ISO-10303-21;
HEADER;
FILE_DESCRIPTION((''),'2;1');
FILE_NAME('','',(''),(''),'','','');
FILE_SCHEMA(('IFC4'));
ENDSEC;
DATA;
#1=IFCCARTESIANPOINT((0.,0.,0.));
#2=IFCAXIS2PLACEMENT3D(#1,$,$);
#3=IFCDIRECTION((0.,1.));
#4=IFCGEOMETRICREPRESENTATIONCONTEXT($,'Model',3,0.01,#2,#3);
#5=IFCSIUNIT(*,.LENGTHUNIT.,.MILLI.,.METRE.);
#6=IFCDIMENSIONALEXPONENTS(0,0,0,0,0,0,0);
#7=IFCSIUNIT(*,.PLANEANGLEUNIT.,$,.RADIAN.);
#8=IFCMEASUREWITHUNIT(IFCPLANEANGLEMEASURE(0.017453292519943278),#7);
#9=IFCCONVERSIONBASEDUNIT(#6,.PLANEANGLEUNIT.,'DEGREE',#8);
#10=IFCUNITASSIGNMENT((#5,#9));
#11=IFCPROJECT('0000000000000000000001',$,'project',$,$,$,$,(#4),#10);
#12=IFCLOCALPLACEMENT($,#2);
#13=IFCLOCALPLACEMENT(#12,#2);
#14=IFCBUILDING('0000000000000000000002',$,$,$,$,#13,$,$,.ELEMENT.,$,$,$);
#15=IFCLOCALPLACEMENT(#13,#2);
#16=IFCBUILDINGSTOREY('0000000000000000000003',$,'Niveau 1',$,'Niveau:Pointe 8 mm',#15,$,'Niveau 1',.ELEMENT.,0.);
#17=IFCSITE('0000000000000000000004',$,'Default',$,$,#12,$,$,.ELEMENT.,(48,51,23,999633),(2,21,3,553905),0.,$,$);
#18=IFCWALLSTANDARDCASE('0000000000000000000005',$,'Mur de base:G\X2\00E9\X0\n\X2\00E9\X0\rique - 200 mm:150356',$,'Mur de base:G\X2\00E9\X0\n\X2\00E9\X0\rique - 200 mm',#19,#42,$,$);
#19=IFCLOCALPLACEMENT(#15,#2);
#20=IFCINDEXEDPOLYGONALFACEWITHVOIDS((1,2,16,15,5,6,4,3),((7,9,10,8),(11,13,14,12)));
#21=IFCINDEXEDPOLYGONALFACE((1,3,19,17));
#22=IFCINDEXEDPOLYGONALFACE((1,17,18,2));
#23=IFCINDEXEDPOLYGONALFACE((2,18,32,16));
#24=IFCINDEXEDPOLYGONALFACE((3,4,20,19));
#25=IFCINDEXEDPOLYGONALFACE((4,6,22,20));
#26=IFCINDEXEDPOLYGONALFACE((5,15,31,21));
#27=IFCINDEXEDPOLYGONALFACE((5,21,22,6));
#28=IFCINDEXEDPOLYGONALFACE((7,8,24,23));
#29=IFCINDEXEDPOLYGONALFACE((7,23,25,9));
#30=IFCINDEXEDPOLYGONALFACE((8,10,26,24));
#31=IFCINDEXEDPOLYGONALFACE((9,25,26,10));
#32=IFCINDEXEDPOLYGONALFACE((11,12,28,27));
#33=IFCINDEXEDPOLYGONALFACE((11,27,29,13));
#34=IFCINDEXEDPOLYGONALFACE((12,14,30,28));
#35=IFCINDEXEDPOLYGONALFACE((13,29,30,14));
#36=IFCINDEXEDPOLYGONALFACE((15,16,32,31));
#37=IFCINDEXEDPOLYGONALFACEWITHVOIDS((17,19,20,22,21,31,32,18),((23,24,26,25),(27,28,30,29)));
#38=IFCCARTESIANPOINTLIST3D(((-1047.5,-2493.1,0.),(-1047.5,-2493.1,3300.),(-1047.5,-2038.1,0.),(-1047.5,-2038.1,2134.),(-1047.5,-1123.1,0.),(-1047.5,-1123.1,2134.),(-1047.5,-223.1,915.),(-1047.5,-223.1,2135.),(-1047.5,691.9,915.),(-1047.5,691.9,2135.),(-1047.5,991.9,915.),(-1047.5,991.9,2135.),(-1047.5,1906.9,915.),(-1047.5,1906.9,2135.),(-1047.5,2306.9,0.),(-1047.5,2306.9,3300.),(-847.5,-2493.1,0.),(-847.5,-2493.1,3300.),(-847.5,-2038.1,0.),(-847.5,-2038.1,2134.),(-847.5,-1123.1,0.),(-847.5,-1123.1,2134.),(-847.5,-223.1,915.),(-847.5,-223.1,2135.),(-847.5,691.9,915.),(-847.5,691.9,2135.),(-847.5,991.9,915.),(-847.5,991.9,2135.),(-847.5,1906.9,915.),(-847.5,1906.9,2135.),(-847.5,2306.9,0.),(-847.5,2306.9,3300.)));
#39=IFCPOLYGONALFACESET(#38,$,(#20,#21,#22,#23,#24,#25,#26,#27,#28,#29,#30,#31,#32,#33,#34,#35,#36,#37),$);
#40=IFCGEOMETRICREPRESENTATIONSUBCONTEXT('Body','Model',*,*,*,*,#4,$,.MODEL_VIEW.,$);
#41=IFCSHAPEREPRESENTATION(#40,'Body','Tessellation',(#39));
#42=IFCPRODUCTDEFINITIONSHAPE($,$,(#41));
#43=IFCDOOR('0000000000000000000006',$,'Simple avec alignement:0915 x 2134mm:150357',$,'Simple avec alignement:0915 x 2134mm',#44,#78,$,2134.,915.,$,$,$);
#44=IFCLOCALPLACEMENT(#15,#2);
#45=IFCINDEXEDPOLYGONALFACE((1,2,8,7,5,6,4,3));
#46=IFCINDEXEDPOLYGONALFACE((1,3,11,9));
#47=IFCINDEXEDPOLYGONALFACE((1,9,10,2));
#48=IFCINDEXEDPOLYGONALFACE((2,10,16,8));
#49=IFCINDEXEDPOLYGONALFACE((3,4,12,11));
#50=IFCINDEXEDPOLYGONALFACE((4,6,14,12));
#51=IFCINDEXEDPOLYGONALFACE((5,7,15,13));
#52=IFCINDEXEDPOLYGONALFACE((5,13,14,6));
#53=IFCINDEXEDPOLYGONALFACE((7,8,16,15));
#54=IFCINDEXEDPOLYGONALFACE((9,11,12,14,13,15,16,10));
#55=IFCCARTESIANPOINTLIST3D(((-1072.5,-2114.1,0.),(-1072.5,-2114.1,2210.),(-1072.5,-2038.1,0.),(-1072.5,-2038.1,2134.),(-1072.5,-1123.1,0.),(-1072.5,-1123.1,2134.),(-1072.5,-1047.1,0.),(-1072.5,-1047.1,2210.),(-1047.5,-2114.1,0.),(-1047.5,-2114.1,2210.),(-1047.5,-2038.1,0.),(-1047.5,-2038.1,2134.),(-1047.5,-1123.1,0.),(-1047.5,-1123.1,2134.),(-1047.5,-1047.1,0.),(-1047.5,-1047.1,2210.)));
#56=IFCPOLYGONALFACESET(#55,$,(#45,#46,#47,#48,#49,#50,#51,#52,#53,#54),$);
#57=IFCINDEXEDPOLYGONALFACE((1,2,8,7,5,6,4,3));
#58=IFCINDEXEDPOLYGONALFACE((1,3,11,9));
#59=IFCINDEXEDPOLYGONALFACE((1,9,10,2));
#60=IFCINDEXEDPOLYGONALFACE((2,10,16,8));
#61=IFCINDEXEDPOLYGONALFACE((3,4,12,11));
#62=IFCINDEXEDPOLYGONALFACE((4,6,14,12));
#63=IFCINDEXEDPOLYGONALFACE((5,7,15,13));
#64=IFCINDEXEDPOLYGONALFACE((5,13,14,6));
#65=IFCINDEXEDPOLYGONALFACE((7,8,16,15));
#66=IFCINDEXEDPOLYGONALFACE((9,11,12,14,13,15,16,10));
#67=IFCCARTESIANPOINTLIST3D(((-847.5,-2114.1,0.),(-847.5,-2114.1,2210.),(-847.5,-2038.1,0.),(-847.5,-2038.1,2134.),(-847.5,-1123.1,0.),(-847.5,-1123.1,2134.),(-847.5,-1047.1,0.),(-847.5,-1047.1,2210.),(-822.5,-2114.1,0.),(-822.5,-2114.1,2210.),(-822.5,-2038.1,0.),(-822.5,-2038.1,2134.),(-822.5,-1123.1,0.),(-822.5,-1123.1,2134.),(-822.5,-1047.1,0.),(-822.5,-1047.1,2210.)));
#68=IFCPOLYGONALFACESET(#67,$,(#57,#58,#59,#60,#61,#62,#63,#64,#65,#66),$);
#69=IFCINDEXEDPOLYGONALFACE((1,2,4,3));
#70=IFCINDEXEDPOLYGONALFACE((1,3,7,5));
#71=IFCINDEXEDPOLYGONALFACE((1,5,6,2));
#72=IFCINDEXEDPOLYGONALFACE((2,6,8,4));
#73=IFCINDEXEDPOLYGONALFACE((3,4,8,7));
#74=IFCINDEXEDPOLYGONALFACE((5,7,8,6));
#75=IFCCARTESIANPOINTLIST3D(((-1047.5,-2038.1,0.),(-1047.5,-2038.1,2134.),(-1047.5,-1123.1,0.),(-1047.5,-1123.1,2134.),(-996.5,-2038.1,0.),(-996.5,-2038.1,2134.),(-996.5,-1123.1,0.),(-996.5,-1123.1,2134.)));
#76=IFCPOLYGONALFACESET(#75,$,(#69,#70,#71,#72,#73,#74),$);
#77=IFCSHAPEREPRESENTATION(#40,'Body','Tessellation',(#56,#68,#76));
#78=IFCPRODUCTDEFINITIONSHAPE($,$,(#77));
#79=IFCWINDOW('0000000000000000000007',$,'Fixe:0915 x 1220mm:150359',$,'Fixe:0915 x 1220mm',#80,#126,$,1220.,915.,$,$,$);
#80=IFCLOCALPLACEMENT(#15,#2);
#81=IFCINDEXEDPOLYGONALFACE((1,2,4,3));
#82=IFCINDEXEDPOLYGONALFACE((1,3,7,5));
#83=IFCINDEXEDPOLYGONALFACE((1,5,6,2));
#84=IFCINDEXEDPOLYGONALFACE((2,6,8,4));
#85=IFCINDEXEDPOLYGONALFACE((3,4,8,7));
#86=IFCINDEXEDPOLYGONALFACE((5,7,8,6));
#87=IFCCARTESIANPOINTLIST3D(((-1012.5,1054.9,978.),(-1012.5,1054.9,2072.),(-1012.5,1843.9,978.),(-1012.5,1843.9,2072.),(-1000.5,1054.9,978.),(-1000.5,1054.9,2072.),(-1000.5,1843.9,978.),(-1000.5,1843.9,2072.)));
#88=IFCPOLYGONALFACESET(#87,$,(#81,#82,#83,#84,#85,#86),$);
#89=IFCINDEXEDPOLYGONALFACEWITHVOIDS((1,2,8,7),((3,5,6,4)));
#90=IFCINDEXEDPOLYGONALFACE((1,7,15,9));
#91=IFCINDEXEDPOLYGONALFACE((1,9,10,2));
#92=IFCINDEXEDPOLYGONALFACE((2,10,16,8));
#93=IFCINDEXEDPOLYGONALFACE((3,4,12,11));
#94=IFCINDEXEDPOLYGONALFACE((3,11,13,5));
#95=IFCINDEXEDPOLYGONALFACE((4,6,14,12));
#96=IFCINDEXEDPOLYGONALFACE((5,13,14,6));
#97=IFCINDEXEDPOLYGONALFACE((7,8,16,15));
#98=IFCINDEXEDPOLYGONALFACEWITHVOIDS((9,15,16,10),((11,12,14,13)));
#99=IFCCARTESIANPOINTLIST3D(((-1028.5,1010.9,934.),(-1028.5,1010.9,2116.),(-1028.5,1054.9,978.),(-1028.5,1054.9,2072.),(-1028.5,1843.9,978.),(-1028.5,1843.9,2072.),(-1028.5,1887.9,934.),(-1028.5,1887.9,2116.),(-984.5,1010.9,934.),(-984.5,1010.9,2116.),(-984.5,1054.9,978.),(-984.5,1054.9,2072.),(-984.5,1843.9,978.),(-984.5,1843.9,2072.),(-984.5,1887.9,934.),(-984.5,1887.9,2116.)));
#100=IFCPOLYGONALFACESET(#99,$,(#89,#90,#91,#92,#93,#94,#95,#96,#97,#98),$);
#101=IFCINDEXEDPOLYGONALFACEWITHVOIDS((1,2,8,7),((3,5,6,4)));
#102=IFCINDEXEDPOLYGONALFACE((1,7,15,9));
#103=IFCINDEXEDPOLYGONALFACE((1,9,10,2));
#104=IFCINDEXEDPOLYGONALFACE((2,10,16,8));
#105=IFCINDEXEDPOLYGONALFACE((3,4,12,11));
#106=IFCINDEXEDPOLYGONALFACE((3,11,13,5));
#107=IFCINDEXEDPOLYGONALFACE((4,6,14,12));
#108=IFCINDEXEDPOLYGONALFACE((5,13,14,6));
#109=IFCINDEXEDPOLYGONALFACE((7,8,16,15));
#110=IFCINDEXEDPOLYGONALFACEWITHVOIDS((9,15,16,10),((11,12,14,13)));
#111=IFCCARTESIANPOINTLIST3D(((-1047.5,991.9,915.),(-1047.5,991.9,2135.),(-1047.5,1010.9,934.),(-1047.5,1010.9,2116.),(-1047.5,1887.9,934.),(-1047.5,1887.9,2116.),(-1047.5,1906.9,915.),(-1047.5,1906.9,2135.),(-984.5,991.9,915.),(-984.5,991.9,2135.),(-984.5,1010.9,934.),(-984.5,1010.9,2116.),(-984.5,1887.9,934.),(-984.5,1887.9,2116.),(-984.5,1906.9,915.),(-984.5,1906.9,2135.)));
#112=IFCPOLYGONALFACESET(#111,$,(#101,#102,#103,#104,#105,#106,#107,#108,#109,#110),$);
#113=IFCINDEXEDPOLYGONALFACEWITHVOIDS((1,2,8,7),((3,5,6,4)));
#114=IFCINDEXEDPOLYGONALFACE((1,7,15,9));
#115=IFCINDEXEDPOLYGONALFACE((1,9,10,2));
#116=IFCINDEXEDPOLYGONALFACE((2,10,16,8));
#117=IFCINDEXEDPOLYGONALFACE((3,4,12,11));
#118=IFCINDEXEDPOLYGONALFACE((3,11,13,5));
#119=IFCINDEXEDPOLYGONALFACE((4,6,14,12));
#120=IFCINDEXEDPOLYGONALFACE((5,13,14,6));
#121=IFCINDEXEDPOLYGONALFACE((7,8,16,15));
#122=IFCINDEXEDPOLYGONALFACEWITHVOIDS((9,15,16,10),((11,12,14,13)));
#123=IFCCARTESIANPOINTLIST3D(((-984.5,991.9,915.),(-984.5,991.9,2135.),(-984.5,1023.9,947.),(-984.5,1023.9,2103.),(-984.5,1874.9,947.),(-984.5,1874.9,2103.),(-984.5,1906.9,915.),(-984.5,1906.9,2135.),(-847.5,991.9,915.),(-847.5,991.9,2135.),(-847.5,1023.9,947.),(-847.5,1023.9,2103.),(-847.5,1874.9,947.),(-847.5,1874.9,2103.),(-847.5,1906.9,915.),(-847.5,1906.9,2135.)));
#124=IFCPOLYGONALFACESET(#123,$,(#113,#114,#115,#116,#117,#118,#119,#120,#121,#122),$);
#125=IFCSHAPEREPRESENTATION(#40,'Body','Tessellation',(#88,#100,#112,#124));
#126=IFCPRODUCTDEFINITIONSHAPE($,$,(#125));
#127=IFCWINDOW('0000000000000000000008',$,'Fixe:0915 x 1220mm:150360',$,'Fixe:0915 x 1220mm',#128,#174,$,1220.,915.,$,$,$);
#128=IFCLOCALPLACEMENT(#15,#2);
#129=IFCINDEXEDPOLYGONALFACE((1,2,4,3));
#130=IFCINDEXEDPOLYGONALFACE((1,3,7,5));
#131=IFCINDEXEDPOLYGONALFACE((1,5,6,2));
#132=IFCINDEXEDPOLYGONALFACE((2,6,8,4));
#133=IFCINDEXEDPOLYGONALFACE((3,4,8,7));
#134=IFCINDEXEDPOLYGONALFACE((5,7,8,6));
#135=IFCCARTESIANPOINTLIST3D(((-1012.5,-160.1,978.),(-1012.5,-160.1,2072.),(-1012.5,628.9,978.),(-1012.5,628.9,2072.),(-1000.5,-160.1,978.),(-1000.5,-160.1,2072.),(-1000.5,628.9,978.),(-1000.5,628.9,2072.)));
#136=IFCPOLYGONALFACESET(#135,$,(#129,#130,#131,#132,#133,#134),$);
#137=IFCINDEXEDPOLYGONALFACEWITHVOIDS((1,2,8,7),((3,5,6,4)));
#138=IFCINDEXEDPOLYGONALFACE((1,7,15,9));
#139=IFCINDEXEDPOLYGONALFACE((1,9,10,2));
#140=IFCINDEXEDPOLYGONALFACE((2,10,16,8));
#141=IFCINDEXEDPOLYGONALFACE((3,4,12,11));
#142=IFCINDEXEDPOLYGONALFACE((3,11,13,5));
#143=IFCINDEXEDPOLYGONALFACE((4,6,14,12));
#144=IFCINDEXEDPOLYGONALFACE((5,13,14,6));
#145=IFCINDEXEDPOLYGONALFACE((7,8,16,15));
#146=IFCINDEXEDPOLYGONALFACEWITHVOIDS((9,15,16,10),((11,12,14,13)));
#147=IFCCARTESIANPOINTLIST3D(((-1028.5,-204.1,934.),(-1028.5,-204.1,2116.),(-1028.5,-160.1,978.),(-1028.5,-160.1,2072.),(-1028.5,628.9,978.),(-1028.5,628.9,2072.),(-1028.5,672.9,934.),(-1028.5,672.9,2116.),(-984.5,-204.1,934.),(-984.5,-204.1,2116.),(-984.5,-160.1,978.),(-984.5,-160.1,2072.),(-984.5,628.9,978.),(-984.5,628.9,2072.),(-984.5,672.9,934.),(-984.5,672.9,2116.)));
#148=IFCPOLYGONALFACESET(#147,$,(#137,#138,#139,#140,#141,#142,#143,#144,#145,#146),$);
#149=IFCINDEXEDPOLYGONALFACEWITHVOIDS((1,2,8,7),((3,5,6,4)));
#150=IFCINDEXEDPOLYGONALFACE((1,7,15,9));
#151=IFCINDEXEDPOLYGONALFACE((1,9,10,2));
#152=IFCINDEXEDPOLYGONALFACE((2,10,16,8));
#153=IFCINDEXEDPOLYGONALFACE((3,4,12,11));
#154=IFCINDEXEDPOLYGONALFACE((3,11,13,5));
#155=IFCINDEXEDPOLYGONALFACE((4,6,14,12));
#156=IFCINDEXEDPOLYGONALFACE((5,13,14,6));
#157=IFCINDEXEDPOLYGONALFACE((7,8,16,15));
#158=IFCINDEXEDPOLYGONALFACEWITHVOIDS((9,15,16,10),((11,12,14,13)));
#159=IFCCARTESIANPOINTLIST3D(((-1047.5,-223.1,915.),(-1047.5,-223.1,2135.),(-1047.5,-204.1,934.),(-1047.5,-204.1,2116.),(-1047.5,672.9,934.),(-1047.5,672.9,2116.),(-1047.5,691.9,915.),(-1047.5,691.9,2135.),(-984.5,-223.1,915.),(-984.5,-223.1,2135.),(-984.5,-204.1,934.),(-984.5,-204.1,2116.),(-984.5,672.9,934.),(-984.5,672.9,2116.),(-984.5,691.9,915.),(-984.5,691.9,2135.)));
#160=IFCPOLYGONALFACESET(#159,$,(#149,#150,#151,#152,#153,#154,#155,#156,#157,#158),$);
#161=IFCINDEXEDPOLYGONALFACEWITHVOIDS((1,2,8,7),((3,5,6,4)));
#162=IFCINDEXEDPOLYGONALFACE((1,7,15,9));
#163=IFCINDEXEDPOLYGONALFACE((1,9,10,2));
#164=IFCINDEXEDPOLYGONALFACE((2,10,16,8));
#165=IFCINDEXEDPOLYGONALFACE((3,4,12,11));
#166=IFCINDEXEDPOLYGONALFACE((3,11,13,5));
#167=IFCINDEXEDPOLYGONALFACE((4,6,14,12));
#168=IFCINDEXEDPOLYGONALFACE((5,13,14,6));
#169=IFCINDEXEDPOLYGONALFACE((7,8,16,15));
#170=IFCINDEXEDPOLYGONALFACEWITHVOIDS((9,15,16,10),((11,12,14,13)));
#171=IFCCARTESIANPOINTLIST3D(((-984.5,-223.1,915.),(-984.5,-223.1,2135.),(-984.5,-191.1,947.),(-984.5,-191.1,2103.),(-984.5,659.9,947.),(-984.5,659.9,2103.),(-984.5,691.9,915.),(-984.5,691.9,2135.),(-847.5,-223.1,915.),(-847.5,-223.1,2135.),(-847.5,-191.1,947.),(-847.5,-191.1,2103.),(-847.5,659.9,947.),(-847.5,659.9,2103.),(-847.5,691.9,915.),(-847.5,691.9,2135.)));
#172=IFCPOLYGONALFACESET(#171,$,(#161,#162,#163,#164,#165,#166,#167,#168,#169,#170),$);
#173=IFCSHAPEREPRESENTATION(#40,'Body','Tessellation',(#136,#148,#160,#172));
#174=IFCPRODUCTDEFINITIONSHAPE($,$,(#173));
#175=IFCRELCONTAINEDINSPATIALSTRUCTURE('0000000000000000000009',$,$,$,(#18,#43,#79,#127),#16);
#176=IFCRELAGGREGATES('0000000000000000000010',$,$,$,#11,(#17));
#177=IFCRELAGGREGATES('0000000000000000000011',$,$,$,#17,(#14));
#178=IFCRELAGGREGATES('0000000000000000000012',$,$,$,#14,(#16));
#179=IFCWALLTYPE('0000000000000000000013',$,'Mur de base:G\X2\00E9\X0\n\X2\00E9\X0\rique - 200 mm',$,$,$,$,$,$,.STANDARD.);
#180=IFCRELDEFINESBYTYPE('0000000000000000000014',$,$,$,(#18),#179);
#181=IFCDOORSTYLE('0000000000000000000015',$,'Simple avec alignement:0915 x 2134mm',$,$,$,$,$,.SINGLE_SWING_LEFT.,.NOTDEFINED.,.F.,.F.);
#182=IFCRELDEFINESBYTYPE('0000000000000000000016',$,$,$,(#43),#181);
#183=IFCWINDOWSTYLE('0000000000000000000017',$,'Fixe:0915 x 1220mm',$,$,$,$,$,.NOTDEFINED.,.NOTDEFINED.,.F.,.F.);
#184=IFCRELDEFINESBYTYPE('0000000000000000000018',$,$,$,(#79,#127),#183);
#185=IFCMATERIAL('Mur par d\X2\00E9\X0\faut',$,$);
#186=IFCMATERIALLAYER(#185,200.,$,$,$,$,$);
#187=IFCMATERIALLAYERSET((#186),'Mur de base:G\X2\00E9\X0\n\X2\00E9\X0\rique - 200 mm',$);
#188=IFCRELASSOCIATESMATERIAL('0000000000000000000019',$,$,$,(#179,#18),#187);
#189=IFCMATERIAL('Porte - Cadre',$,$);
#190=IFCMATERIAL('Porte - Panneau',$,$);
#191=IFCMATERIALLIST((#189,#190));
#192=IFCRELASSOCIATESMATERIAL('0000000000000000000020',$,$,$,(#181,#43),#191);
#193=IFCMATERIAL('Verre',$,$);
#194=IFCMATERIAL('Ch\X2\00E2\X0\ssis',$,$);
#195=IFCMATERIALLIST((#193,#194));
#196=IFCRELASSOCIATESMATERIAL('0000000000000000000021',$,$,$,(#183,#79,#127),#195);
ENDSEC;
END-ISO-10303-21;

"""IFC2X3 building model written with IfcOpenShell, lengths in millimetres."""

from ifc_helpers import new_model, entity, si_unit, converted_unit, direction, frame, frame_2d, origin, place, context, subcontext, project, spatial, polyline, rectangle, outline, extrude, source, transform, mapped, material, material_list, layer, layer_set, layer_usage, type_object, type_shapes, element, fill, save


model = new_model("IFC2X3")

# Units and contexts
model_context = context("Model", 3, precision=0.01, world=origin(), true_north=direction((0.0, 1.0)))
body_context = subcontext(model_context, "Body", "Model", "MODEL_VIEW")
ifc_project = project(units=[si_unit("LENGTHUNIT", "METRE", prefix="MILLI"), converted_unit("PLANEANGLEUNIT", "DEGREE", entity("IfcPlaneAngleMeasure", 0.017453292519943278), si_unit("PLANEANGLEUNIT", "RADIAN"), dimensions=[0, 0, 0, 0, 0, 0, 0])], contexts=[model_context])

# Site, building, storey
site_placement = place(None, origin())
site = spatial("IfcSite", under=ifc_project, at=site_placement, Name="Default", CompositionType="ELEMENT", RefLatitude=(48, 51, 23, 999633), RefLongitude=(2, 21, 3, 553905), RefElevation=0.0)
building_placement = place(site_placement, origin())
building = spatial("IfcBuilding", under=site, at=building_placement, CompositionType="ELEMENT")
storey_placement = place(building_placement, origin())
storey = spatial("IfcBuildingStorey", under=building, at=storey_placement, Name="Niveau 1", ObjectType="Niveau:Pointe 8 mm", LongName="Niveau 1", CompositionType="ELEMENT", Elevation=0.0)

# Shared definitions
ifc_material_1 = material(Name="Mur par défaut")
ifc_layer_1 = layer(ifc_material_1, 200.0)
ifc_layer_set_1 = layer_set([ifc_layer_1], Name="Mur de base:Générique - 200 mm")
wall_type = type_object("IfcWallType", Name="Mur de base:Générique - 200 mm", PredefinedType="STANDARD", material=ifc_layer_set_1)

# Wall, openings, door, windows
ifc_layer_usage_1 = layer_usage(ifc_layer_set_1, "AXIS2", "NEGATIVE", 100.0)
wall_1_placement = place(storey_placement, frame((-947.5, -2493.1, 0.0), z_axis=(0.0, 0.0, 1.0), x_axis=(0.0, 1.0, 0.0)))
wall_1 = element("IfcWallStandardCase", 1, at=wall_1_placement, inside=storey, type_object=wall_type, material=ifc_layer_usage_1, Name="Mur de base:Générique - 200 mm:150356", ObjectType="Mur de base:Générique - 200 mm", context=body_context, shape_type="SweptSolid", body=[
    extrude(rectangle(XDim=4800.0, YDim=200.0, at=frame_2d((2400.0, 0.0), x_axis=(-1.0, 0.0))), origin(), (0.0, 0.0, 1.0), 3300.0),
])
opening_1_placement = place(wall_1_placement, frame((455.0, -100.0, 0.0)))
opening_1 = element("IfcOpeningElement", 2, at=opening_1_placement, cuts=wall_1, ObjectType="Opening", context=body_context, shape_type="SweptSolid", body=[
    extrude(rectangle(XDim=915.0, YDim=2134.0, at=frame_2d((1067.0, 457.5), x_axis=(0.0, -1.0))), frame((0.0, 0.0, 0.0), z_axis=(0.0, 1.0, 0.0), x_axis=(0.0, 0.0, 1.0)), (0.0, 0.0, 1.0), 200.0),
])
opening_2_placement = place(wall_1_placement, frame((3485.0, -100.0, 915.0)))
opening_2 = element("IfcOpeningElement", 3, at=opening_2_placement, cuts=wall_1, ObjectType="Opening", context=body_context, shape_type="SweptSolid", body=[
    extrude(rectangle(XDim=1220.0, YDim=915.0, at=frame_2d((610.0, 457.5), x_axis=(1.0, 0.0))), frame((0.0, 0.0, 0.0), z_axis=(0.0, 1.0, 0.0), x_axis=(0.0, 0.0, 1.0)), (0.0, 0.0, 1.0), 200.0),
])
opening_3_placement = place(wall_1_placement, frame((2270.0, -100.0, 915.0)))
opening_3 = element("IfcOpeningElement", 4, at=opening_3_placement, cuts=wall_1, ObjectType="Opening", context=body_context, shape_type="SweptSolid", body=[
    extrude(rectangle(XDim=1220.0, YDim=915.0, at=frame_2d((610.0, 457.5), x_axis=(1.0, 0.0))), frame((0.0, 0.0, 0.0), z_axis=(0.0, 1.0, 0.0), x_axis=(0.0, 0.0, 1.0)), (0.0, 0.0, 1.0), 200.0),
])
ifc_material_2 = material(Name="Porte - Cadre")
ifc_material_3 = material(Name="Porte - Panneau")
ifc_material_list_1 = material_list([ifc_material_2, ifc_material_3])
door_style = type_object("IfcDoorStyle", Name="Simple avec alignement:0915 x 2134mm", ConstructionType="NOTDEFINED", OperationType="SINGLE_SWING_LEFT", ParameterTakesPrecedence=False, Sizeable=False, material=ifc_material_list_1)
shared_shape_1 = source(origin(), body_context, "Body", "SweptSolid", [
    extrude(outline(polyline([(-533.5, -1124.0), (533.5, -1124.0), (533.5, 1086.0), (457.5, 1086.0), (457.5, -1048.0), (-457.5, -1048.0), (-457.5, 1086.0), (-533.5, 1086.0), (-533.5, -1124.0)])), frame((457.5, 225.0, 1086.0), z_axis=(0.0, -1.0, 0.0), x_axis=(-1.0, 0.0, 0.0)), (0.0, 0.0, 1.0), 25.0),
    extrude(outline(polyline([(-1124.0, -533.5), (1086.0, -533.5), (1086.0, -457.5), (-1048.0, -457.5), (-1048.0, 457.5), (1086.0, 457.5), (1086.0, 533.5), (-1124.0, 533.5), (-1124.0, -533.5)])), frame((457.5, 0.0, 1086.0), z_axis=(0.0, -1.0, 0.0), x_axis=(0.0, 0.0, -1.0)), (0.0, 0.0, 1.0), 25.0),
    extrude(rectangle(XDim=915.0, YDim=51.0, at=frame_2d((0.0, 0.0), x_axis=(1.0, 0.0))), frame((457.5, 174.5, 0.0)), (0.0, 0.0, 1.0), 2134.0),
])
type_shapes(door_style, [shared_shape_1])
door_placement = place(opening_1_placement, origin())
door = element("IfcDoor", 5, at=door_placement, inside=storey, type_object=door_style, material=ifc_material_list_1, Name="Simple avec alignement:0915 x 2134mm:150357", ObjectType="Simple avec alignement:0915 x 2134mm", OverallHeight=2134.0, OverallWidth=915.0, context=body_context, shape_type="MappedRepresentation", body=[
    mapped(shared_shape_1, transform((0.0, 0.0, 0.0), scale=1.0)),
])
fill(opening_1, door)
ifc_material_4 = material(Name="Verre")
ifc_material_5 = material(Name="Châssis")
ifc_material_list_2 = material_list([ifc_material_4, ifc_material_5])
window_style = type_object("IfcWindowStyle", Name="Fixe:0915 x 1220mm", ConstructionType="NOTDEFINED", OperationType="NOTDEFINED", ParameterTakesPrecedence=False, Sizeable=False, material=ifc_material_list_2)
shared_shape_2 = source(origin(), body_context, "Body", "SweptSolid", [
    extrude(rectangle(XDim=12.0, YDim=789.0, at=frame_2d((0.0, 0.0), x_axis=(1.0, 0.0))), frame((457.5, 159.0, 63.0), z_axis=(0.0, 0.0, 1.0), x_axis=(0.0, -1.0, 0.0)), (0.0, 0.0, 1.0), 1094.0),
    extrude(outline(polyline([(-438.5, -591.0), (438.5, -591.0), (438.5, 591.0), (-438.5, 591.0), (-438.5, -591.0)]), holes=[polyline([(-394.5, -547.0), (-394.5, 547.0), (394.5, 547.0), (394.5, -547.0), (-394.5, -547.0)])]), frame((457.5, 137.0, 610.0), z_axis=(0.0, 1.0, 0.0), x_axis=(1.0, 0.0, 0.0)), (0.0, 0.0, 1.0), 44.0),
    extrude(outline(polyline([(-457.5, -610.0), (457.5, -610.0), (457.5, 610.0), (-457.5, 610.0), (-457.5, -610.0)]), holes=[polyline([(-438.5, -591.0), (-438.5, 591.0), (438.5, 591.0), (438.5, -591.0), (-438.5, -591.0)])]), frame((457.5, 137.0, 610.0), z_axis=(0.0, 1.0, 0.0), x_axis=(1.0, 0.0, 0.0)), (0.0, 0.0, 1.0), 63.0),
    extrude(outline(polyline([(-457.5, -610.0), (457.5, -610.0), (457.5, 610.0), (-457.5, 610.0), (-457.5, -610.0)]), holes=[polyline([(-425.5, -578.0), (-425.5, 578.0), (425.5, 578.0), (425.5, -578.0), (-425.5, -578.0)])]), frame((457.5, 0.0, 610.0), z_axis=(0.0, 1.0, 0.0), x_axis=(1.0, 0.0, 0.0)), (0.0, 0.0, 1.0), 137.0),
])
type_shapes(window_style, [shared_shape_2])
window_1_placement = place(opening_2_placement, origin())
window_1 = element("IfcWindow", 6, at=window_1_placement, inside=storey, type_object=window_style, material=ifc_material_list_2, Name="Fixe:0915 x 1220mm:150359", ObjectType="Fixe:0915 x 1220mm", OverallHeight=1220.0, OverallWidth=915.0, context=body_context, shape_type="MappedRepresentation", body=[
    mapped(shared_shape_2, transform((0.0, 0.0, 0.0), scale=1.0)),
])
fill(opening_2, window_1)
window_2_placement = place(opening_3_placement, origin())
window_2 = element("IfcWindow", 7, at=window_2_placement, inside=storey, type_object=window_style, material=ifc_material_list_2, Name="Fixe:0915 x 1220mm:150360", ObjectType="Fixe:0915 x 1220mm", OverallHeight=1220.0, OverallWidth=915.0, context=body_context, shape_type="MappedRepresentation", body=[
    mapped(shared_shape_2, transform((0.0, 0.0, 0.0), scale=1.0)),
])
fill(opening_3, window_2)

save(model, "model.ifc")
